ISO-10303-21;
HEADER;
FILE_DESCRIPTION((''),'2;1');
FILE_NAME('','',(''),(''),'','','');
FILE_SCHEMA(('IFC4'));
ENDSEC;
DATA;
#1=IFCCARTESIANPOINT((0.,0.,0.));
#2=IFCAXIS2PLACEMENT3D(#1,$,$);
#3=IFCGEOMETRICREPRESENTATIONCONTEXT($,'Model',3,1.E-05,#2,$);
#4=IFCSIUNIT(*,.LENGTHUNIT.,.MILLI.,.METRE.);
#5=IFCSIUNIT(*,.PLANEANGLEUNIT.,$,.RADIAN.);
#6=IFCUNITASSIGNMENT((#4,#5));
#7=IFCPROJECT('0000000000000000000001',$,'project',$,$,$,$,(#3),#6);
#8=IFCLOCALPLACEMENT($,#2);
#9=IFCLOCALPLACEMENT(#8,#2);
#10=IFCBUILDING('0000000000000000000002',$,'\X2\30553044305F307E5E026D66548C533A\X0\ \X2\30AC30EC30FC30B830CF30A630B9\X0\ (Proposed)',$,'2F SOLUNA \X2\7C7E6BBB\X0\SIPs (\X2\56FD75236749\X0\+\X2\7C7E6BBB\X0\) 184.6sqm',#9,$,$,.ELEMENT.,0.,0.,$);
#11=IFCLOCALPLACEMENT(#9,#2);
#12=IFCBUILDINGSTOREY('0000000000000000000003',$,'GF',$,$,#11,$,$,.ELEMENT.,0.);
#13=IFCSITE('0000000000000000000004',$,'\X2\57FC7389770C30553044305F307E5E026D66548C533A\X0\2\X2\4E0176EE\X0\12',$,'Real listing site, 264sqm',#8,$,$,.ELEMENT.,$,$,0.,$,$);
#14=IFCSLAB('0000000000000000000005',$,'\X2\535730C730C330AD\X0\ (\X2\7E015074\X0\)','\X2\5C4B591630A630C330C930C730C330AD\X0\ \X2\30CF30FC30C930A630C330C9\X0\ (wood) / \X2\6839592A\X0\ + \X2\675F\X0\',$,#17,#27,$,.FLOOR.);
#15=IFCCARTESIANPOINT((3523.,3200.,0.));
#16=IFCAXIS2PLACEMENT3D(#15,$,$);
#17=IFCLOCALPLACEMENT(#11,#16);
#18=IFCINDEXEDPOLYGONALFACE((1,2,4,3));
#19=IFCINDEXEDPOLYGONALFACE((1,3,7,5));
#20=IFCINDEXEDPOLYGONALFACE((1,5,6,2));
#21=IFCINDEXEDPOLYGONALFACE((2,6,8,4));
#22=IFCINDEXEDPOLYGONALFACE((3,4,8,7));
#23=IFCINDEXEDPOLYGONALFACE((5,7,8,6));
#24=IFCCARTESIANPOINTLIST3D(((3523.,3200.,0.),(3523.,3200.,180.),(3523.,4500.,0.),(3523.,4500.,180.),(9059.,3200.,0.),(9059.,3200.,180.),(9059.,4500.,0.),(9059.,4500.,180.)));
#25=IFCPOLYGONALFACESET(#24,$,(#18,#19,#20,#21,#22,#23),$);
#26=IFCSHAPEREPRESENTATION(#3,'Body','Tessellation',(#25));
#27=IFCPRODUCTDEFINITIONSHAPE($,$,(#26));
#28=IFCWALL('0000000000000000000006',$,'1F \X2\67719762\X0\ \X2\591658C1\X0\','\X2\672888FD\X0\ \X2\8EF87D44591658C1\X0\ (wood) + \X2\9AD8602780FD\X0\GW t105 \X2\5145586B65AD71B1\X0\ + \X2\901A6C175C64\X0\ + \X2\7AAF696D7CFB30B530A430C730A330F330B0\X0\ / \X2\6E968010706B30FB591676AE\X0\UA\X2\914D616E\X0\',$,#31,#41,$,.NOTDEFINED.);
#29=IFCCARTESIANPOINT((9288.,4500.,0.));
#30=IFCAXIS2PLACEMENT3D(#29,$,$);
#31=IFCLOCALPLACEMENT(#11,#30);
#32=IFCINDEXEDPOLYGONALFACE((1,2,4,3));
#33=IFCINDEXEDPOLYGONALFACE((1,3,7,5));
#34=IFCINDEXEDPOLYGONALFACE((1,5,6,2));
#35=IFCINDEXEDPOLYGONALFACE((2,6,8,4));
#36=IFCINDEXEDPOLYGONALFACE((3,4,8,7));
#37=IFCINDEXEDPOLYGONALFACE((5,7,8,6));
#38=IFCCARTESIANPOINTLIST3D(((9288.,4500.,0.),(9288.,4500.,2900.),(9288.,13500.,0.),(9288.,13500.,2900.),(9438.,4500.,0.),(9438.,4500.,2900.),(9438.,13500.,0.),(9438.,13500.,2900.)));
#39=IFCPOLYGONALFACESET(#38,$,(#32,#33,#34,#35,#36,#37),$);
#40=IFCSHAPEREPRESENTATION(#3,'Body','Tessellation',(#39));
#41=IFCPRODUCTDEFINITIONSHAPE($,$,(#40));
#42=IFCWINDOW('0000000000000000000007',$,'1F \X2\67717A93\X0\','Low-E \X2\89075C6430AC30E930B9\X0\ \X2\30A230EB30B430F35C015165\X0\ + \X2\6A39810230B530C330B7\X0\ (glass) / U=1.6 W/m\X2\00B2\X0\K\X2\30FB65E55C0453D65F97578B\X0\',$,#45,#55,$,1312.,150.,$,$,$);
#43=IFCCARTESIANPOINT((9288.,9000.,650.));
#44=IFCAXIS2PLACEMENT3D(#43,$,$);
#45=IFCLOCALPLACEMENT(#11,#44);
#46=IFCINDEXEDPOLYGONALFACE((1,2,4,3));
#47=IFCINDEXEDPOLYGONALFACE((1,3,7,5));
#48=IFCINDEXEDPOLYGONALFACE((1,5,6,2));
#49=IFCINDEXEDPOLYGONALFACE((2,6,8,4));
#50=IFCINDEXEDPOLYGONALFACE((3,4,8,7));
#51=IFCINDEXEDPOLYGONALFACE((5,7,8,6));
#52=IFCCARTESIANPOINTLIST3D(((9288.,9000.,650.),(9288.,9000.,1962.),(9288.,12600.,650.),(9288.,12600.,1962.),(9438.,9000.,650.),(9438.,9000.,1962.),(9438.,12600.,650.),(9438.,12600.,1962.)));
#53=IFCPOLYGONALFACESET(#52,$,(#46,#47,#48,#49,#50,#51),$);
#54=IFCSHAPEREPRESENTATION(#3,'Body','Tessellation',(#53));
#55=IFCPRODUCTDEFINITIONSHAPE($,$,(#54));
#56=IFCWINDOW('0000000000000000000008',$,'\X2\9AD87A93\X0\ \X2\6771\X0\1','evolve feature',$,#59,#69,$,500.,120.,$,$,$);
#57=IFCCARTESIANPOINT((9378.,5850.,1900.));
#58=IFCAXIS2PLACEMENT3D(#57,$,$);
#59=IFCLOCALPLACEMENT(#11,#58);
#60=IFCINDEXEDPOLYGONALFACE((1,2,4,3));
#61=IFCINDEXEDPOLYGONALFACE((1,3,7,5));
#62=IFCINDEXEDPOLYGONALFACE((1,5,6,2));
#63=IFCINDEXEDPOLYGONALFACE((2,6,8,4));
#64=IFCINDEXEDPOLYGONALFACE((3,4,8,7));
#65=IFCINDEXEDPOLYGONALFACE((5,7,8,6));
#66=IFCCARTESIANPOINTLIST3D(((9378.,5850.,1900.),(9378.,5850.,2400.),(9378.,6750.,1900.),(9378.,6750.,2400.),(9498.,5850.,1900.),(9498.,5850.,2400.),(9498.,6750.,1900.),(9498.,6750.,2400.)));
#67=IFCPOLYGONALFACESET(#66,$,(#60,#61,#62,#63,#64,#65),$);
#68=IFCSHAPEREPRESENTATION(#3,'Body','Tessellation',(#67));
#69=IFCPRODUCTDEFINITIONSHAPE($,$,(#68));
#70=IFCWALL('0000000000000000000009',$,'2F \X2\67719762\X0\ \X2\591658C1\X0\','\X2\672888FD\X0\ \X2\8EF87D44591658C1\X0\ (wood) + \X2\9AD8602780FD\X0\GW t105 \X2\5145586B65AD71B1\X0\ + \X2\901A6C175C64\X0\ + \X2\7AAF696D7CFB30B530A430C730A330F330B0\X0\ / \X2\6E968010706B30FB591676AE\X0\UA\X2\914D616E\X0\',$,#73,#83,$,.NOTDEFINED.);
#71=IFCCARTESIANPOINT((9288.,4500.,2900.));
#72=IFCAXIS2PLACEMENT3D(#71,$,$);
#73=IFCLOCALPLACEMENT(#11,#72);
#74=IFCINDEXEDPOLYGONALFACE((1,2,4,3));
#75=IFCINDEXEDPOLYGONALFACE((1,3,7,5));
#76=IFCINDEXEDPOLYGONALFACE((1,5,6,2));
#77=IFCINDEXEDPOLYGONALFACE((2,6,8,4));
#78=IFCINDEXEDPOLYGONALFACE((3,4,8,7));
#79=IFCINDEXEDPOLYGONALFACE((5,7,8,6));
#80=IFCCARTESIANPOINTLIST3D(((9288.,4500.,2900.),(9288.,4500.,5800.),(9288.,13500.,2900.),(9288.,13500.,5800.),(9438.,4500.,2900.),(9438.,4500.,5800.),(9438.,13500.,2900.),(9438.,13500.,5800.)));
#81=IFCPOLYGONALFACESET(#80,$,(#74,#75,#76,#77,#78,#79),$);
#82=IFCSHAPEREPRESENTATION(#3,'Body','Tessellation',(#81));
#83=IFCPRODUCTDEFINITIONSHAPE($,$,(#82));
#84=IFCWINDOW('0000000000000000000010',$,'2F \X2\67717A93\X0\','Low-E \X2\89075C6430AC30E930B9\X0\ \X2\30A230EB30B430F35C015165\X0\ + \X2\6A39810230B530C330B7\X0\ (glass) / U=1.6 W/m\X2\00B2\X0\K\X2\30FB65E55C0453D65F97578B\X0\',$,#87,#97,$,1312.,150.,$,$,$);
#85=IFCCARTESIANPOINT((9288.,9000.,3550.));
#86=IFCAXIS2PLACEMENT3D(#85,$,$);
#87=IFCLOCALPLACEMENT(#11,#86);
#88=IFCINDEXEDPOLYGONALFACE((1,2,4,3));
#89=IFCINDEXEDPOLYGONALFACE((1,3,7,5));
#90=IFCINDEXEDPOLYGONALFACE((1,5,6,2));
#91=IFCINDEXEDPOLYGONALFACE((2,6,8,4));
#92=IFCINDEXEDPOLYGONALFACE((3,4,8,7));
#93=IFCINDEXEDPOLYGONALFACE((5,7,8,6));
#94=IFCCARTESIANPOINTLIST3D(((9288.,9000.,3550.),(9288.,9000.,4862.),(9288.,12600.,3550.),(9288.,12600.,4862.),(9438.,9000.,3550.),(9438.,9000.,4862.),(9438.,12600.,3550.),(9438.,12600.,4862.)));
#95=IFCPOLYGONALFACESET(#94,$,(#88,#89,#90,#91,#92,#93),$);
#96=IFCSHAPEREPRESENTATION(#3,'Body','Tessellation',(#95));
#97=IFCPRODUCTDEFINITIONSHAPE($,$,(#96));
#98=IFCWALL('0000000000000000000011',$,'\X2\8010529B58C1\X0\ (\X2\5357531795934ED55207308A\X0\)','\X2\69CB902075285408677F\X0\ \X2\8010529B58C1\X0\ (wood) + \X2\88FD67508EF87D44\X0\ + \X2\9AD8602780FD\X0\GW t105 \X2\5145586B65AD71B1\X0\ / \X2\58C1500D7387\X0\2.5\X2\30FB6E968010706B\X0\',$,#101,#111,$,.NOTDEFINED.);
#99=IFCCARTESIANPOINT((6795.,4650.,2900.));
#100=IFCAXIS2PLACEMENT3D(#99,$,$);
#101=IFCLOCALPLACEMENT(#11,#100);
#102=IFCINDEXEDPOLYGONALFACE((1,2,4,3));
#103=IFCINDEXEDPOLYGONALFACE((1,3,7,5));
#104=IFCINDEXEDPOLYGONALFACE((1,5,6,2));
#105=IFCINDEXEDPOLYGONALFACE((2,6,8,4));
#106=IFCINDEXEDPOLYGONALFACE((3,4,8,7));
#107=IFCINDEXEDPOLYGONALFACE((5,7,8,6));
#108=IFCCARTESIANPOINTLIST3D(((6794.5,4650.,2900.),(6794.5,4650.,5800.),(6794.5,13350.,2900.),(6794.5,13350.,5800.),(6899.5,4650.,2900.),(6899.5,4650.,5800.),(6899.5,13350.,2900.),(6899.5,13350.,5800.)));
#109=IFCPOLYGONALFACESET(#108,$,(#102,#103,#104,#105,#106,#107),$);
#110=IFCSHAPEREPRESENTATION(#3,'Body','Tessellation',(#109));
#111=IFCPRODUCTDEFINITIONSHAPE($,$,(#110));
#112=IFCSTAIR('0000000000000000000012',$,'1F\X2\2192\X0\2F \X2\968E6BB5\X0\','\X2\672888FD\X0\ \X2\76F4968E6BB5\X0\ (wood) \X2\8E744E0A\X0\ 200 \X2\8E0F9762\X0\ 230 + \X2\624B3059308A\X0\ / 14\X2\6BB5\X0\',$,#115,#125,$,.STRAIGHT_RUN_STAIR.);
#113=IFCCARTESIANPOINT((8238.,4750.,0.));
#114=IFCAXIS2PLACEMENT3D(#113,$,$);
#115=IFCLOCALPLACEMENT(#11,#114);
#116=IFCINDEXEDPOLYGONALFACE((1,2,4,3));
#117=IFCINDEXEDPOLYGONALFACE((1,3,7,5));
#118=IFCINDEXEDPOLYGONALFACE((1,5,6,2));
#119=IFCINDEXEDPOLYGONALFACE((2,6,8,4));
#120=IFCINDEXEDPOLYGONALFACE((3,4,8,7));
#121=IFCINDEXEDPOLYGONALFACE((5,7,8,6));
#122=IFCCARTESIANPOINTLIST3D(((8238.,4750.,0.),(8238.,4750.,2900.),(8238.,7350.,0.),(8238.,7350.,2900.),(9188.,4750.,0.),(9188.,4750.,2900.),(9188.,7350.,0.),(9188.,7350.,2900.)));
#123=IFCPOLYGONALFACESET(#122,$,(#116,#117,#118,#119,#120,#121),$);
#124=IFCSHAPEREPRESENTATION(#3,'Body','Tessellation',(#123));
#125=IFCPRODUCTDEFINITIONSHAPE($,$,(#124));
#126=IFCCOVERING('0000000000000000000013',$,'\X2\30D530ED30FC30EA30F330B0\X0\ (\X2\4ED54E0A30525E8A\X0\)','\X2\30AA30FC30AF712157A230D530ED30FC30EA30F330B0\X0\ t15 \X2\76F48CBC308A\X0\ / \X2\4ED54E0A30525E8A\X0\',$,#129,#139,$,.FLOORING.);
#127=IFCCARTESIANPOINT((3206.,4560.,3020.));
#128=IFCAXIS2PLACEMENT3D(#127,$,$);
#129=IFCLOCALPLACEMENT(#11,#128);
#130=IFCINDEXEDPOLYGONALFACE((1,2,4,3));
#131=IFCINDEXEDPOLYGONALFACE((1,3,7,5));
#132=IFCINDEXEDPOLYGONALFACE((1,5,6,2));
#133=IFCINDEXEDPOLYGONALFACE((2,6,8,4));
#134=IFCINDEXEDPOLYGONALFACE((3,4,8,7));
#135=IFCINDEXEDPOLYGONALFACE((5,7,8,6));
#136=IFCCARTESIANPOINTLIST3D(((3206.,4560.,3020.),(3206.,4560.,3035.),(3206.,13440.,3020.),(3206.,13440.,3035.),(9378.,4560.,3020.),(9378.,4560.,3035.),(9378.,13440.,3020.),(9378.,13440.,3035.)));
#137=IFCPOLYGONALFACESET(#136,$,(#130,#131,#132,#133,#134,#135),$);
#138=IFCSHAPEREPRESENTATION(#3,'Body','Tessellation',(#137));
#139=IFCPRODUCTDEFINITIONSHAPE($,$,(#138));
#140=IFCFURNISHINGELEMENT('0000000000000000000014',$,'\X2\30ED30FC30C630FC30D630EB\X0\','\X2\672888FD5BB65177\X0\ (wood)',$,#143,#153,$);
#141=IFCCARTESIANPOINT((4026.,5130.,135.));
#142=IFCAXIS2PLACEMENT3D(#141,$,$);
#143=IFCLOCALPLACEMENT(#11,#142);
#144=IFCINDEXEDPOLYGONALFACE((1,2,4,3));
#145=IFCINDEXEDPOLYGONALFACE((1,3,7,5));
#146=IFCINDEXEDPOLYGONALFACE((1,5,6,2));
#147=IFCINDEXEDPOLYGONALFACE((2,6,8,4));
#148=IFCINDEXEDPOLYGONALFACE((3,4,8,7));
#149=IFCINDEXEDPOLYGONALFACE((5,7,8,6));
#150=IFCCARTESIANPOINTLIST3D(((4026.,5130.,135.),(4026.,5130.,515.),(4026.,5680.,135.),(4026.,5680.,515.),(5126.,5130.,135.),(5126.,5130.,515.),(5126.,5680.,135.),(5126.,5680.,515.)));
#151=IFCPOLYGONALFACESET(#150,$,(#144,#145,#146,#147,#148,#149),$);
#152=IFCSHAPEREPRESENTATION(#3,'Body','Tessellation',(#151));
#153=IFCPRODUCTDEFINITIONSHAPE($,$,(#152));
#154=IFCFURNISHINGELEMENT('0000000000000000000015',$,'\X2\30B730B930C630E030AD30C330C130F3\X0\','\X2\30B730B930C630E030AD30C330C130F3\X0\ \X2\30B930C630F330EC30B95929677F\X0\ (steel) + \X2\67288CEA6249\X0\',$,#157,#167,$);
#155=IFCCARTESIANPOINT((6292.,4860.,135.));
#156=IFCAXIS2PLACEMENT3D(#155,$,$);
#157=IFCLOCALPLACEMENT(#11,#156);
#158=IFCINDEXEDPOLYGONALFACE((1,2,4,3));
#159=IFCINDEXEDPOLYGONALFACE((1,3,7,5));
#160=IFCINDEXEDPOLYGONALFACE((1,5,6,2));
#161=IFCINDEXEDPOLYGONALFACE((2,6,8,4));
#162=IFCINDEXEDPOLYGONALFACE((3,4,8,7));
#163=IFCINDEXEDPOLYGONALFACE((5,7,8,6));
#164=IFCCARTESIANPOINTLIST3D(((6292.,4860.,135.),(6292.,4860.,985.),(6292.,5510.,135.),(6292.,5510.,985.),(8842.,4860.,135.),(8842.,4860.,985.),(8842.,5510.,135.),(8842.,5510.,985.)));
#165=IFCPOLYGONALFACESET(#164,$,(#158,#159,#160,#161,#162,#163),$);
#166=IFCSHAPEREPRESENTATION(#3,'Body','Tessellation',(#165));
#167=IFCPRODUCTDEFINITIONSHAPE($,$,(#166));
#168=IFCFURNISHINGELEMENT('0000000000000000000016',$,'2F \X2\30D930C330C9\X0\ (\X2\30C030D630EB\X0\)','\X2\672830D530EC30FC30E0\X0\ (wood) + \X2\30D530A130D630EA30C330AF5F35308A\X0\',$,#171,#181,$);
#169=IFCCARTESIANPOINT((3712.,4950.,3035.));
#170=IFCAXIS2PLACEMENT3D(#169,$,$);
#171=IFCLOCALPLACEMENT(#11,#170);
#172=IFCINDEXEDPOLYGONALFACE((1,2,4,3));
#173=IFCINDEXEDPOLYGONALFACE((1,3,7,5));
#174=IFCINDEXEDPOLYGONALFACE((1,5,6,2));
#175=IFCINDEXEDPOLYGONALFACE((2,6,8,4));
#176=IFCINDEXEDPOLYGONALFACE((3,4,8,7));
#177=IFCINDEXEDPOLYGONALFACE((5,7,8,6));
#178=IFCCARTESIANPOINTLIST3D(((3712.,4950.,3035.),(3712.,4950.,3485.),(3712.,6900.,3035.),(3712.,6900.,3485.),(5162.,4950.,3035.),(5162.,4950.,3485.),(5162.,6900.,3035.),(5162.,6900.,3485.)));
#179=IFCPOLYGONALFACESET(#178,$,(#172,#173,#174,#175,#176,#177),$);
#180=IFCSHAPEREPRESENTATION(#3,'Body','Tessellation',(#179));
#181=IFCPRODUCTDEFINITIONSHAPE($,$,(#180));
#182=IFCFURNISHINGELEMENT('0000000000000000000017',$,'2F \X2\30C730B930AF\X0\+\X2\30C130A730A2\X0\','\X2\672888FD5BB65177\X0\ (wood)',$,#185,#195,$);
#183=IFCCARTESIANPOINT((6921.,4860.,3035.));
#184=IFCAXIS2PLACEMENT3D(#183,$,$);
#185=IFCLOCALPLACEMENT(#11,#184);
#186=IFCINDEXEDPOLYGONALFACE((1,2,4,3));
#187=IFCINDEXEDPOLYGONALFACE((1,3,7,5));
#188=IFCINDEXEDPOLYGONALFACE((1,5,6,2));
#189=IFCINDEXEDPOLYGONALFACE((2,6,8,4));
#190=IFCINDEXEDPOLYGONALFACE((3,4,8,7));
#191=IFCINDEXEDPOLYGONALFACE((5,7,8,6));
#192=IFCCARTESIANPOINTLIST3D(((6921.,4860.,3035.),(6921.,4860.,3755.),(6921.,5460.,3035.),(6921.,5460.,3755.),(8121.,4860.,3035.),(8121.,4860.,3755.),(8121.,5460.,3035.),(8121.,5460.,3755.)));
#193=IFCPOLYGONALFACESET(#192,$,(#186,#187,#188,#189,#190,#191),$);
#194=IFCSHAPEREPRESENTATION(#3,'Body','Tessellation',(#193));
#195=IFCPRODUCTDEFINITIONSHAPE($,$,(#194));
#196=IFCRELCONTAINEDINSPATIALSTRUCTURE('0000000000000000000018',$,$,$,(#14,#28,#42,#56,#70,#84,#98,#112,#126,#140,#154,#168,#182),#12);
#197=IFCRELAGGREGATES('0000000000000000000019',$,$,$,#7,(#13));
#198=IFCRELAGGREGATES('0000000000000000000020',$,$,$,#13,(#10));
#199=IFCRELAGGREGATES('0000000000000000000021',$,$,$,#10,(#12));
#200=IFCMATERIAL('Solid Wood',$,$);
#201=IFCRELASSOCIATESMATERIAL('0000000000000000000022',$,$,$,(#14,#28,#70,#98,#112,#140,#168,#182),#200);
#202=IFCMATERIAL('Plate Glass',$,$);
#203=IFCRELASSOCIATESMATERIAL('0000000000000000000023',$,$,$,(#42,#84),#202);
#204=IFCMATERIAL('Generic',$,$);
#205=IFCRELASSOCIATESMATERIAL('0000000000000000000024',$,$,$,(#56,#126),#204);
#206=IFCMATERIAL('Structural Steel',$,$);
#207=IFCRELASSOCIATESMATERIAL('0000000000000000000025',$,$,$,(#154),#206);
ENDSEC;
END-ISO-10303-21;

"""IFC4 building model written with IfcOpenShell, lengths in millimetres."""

from ifc_helpers import new_model, si_unit, frame, frame_2d, origin, place, context, project, spatial, rectangle, extrude, material, element, fill, save


model = new_model("IFC4")

# Units and contexts
model_context = context("Model", 3, precision=1e-05, world=origin())
ifc_project = project(units=[si_unit("LENGTHUNIT", "METRE", prefix="MILLI"), si_unit("PLANEANGLEUNIT", "RADIAN")], contexts=[model_context])

# Site, building, storey
site_placement = place(None, origin())
site = spatial("IfcSite", under=ifc_project, at=site_placement, Name="埼玉県さいたま市浦和区2丁目12", ObjectType="Real listing site, 264sqm", CompositionType="ELEMENT", RefElevation=0.0)
building_placement = place(site_placement, origin())
building = spatial("IfcBuilding", under=site, at=building_placement, Name="さいたま市浦和区 ガレージハウス (Proposed)", ObjectType="2F SOLUNA 籾殻SIPs (国産杉+籾殻) 184.6sqm", CompositionType="ELEMENT", ElevationOfRefHeight=0.0, ElevationOfTerrain=0.0)
storey_placement = place(building_placement, origin())
storey = spatial("IfcBuildingStorey", under=building, at=storey_placement, Name="GF", CompositionType="ELEMENT", Elevation=0.0)

# Slab
ifc_material_1 = material(Name="Solid Wood")
slab_placement = place(storey_placement, frame((3523.0, 3200.0, 0.0)))
element("IfcSlab", 1, at=slab_placement, inside=storey, material=ifc_material_1, Name="南デッキ (縁側)", Description="屋外ウッドデッキ ハードウッド (wood) / 根太 + 束", PredefinedType="FLOOR", context=model_context, shape_type="SweptSolid", body=[
    extrude(rectangle(XDim=5536.0, YDim=1300.0, at=frame_2d((2768.0, 650.0))), frame((3523.0, 3200.0, 0.0)), (0.0, 0.0, 1.0), 180.0),
])

# Wall, openings, windows
wall_1_placement = place(storey_placement, frame((9288.0, 4500.0, 0.0)))
wall_1 = element("IfcWall", 2, at=wall_1_placement, inside=storey, material=ifc_material_1, Name="1F 東面 外壁", Description="木製 軸組外壁 (wood) + 高性能GW t105 充填断熱 + 通気層 + 窯業系サイディング / 準耐火・外皮UA配慮", PredefinedType="NOTDEFINED", context=model_context, shape_type="SweptSolid", body=[
    extrude(rectangle(XDim=150.0, YDim=9000.0, at=frame_2d((75.0, 4500.0))), frame((9288.0, 4500.0, 0.0)), (0.0, 0.0, 1.0), 2900.0),
])
opening_1_placement = place(storey_placement, frame((9288.0, 9000.0, 650.0)))
opening_1 = element("IfcOpeningElement", 3, at=opening_1_placement, cuts=wall_1, PredefinedType="NOTDEFINED", context=model_context, shape_type="SweptSolid", body=[
    extrude(rectangle(XDim=150.0, YDim=3600.0, at=frame_2d((75.0, 1800.0))), frame((9288.0, 9000.0, 650.0)), (0.0, 0.0, 1.0), 1312.0),
])
opening_2_placement = place(storey_placement, frame((9378.0, 5850.0, 1900.0)))
opening_2 = element("IfcOpeningElement", 4, at=opening_2_placement, cuts=wall_1, PredefinedType="NOTDEFINED", context=model_context, shape_type="SweptSolid", body=[
    extrude(rectangle(XDim=120.0, YDim=900.0, at=frame_2d((60.0, 450.0))), frame((9378.0, 5850.0, 1900.0)), (0.0, 0.0, 1.0), 500.0),
])
ifc_material_2 = material(Name="Plate Glass")
window_1_placement = place(storey_placement, frame((9288.0, 9000.0, 650.0)))
window_1 = element("IfcWindow", 5, at=window_1_placement, inside=storey, material=ifc_material_2, Name="1F 東窓", Description="Low-E 複層ガラス アルゴン封入 + 樹脂サッシ (glass) / U=1.6 W/m²K・日射取得型", OverallHeight=1312.0, OverallWidth=150.0, context=model_context, shape_type="SweptSolid", body=[
    extrude(rectangle(XDim=150.0, YDim=3600.0, at=frame_2d((75.0, 1800.0))), frame((9288.0, 9000.0, 650.0)), (0.0, 0.0, 1.0), 1312.0),
])
fill(opening_1, window_1)
ifc_material_3 = material(Name="Generic")
window_2_placement = place(storey_placement, frame((9378.0, 5850.0, 1900.0)))
window_2 = element("IfcWindow", 6, at=window_2_placement, inside=storey, material=ifc_material_3, Name="高窓 東1", Description="evolve feature", OverallHeight=500.0, OverallWidth=120.0, context=model_context, shape_type="SweptSolid", body=[
    extrude(rectangle(XDim=120.0, YDim=900.0, at=frame_2d((60.0, 450.0))), frame((9378.0, 5850.0, 1900.0)), (0.0, 0.0, 1.0), 500.0),
])
fill(opening_2, window_2)

# Wall, opening, window
wall_2_placement = place(storey_placement, frame((9288.0, 4500.0, 2900.0)))
wall_2 = element("IfcWall", 7, at=wall_2_placement, inside=storey, material=ifc_material_1, Name="2F 東面 外壁", Description="木製 軸組外壁 (wood) + 高性能GW t105 充填断熱 + 通気層 + 窯業系サイディング / 準耐火・外皮UA配慮", PredefinedType="NOTDEFINED", context=model_context, shape_type="SweptSolid", body=[
    extrude(rectangle(XDim=150.0, YDim=9000.0, at=frame_2d((75.0, 4500.0))), frame((9288.0, 4500.0, 2900.0)), (0.0, 0.0, 1.0), 2900.0),
])
opening_3_placement = place(storey_placement, frame((9288.0, 9000.0, 3550.0)))
opening_3 = element("IfcOpeningElement", 8, at=opening_3_placement, cuts=wall_2, PredefinedType="NOTDEFINED", context=model_context, shape_type="SweptSolid", body=[
    extrude(rectangle(XDim=150.0, YDim=3600.0, at=frame_2d((75.0, 1800.0))), frame((9288.0, 9000.0, 3550.0)), (0.0, 0.0, 1.0), 1312.0),
])
window_3_placement = place(storey_placement, frame((9288.0, 9000.0, 3550.0)))
window_3 = element("IfcWindow", 9, at=window_3_placement, inside=storey, material=ifc_material_2, Name="2F 東窓", Description="Low-E 複層ガラス アルゴン封入 + 樹脂サッシ (glass) / U=1.6 W/m²K・日射取得型", OverallHeight=1312.0, OverallWidth=150.0, context=model_context, shape_type="SweptSolid", body=[
    extrude(rectangle(XDim=150.0, YDim=3600.0, at=frame_2d((75.0, 1800.0))), frame((9288.0, 9000.0, 3550.0)), (0.0, 0.0, 1.0), 1312.0),
])
fill(opening_3, window_3)

# Wall
wall_3_placement = place(storey_placement, frame((6795.0, 4650.0, 2900.0)))
element("IfcWall", 10, at=wall_3_placement, inside=storey, material=ifc_material_1, Name="耐力壁 (南北間仕切り)", Description="構造用合板 耐力壁 (wood) + 製材軸組 + 高性能GW t105 充填断熱 / 壁倍率2.5・準耐火", PredefinedType="NOTDEFINED", context=model_context, shape_type="SweptSolid", body=[
    extrude(rectangle(XDim=105.0, YDim=8700.0, at=frame_2d((52.0, 4350.0))), frame((6795.0, 4650.0, 2900.0)), (0.0, 0.0, 1.0), 2900.0),
])

# Stair
stair_placement = place(storey_placement, frame((8238.0, 4750.0, 0.0)))
element("IfcStair", 11, at=stair_placement, inside=storey, material=ifc_material_1, Name="1F→2F 階段", Description="木製 直階段 (wood) 蹴上 200 踏面 230 + 手すり / 14段", PredefinedType="STRAIGHT_RUN_STAIR", context=model_context, shape_type="SweptSolid", body=[
    extrude(rectangle(XDim=950.0, YDim=2600.0, at=frame_2d((475.0, 1300.0))), frame((8238.0, 4750.0, 0.0)), (0.0, 0.0, 1.0), 2900.0),
])

# Covering
covering_placement = place(storey_placement, frame((3206.0, 4560.0, 3020.0)))
element("IfcCovering", 12, at=covering_placement, inside=storey, material=ifc_material_3, Name="フローリング (仕上げ床)", Description="オーク無垢フローリング t15 直貼り / 仕上げ床", PredefinedType="FLOORING", context=model_context, shape_type="SweptSolid", body=[
    extrude(rectangle(XDim=6172.0, YDim=8880.0, at=frame_2d((3086.0, 4440.0))), frame((3206.0, 4560.0, 3020.0)), (0.0, 0.0, 1.0), 15.0),
])

# Furnishing elements
furnishing_1_placement = place(storey_placement, frame((4026.0, 5130.0, 135.0)))
element("IfcFurnishingElement", 13, at=furnishing_1_placement, inside=storey, material=ifc_material_1, Name="ローテーブル", Description="木製家具 (wood)", context=model_context, shape_type="SweptSolid", body=[
    extrude(rectangle(XDim=1100.0, YDim=550.0, at=frame_2d((550.0, 275.0))), frame((4026.0, 5130.0, 135.0)), (0.0, 0.0, 1.0), 380.0),
])
ifc_material_4 = material(Name="Structural Steel")
furnishing_2_placement = place(storey_placement, frame((6292.0, 4860.0, 135.0)))
element("IfcFurnishingElement", 14, at=furnishing_2_placement, inside=storey, material=ifc_material_4, Name="システムキッチン", Description="システムキッチン ステンレス天板 (steel) + 木質扉", context=model_context, shape_type="SweptSolid", body=[
    extrude(rectangle(XDim=2550.0, YDim=650.0, at=frame_2d((1275.0, 325.0))), frame((6292.0, 4860.0, 135.0)), (0.0, 0.0, 1.0), 850.0),
])
furnishing_3_placement = place(storey_placement, frame((3712.0, 4950.0, 3035.0)))
element("IfcFurnishingElement", 15, at=furnishing_3_placement, inside=storey, material=ifc_material_1, Name="2F ベッド (ダブル)", Description="木フレーム (wood) + ファブリック張り", context=model_context, shape_type="SweptSolid", body=[
    extrude(rectangle(XDim=1450.0, YDim=1950.0, at=frame_2d((725.0, 975.0))), frame((3712.0, 4950.0, 3035.0)), (0.0, 0.0, 1.0), 450.0),
])
furnishing_4_placement = place(storey_placement, frame((6921.0, 4860.0, 3035.0)))
element("IfcFurnishingElement", 16, at=furnishing_4_placement, inside=storey, material=ifc_material_1, Name="2F デスク+チェア", Description="木製家具 (wood)", context=model_context, shape_type="SweptSolid", body=[
    extrude(rectangle(XDim=1200.0, YDim=600.0, at=frame_2d((600.0, 300.0))), frame((6921.0, 4860.0, 3035.0)), (0.0, 0.0, 1.0), 720.0),
])

save(model, "model.ifc")
